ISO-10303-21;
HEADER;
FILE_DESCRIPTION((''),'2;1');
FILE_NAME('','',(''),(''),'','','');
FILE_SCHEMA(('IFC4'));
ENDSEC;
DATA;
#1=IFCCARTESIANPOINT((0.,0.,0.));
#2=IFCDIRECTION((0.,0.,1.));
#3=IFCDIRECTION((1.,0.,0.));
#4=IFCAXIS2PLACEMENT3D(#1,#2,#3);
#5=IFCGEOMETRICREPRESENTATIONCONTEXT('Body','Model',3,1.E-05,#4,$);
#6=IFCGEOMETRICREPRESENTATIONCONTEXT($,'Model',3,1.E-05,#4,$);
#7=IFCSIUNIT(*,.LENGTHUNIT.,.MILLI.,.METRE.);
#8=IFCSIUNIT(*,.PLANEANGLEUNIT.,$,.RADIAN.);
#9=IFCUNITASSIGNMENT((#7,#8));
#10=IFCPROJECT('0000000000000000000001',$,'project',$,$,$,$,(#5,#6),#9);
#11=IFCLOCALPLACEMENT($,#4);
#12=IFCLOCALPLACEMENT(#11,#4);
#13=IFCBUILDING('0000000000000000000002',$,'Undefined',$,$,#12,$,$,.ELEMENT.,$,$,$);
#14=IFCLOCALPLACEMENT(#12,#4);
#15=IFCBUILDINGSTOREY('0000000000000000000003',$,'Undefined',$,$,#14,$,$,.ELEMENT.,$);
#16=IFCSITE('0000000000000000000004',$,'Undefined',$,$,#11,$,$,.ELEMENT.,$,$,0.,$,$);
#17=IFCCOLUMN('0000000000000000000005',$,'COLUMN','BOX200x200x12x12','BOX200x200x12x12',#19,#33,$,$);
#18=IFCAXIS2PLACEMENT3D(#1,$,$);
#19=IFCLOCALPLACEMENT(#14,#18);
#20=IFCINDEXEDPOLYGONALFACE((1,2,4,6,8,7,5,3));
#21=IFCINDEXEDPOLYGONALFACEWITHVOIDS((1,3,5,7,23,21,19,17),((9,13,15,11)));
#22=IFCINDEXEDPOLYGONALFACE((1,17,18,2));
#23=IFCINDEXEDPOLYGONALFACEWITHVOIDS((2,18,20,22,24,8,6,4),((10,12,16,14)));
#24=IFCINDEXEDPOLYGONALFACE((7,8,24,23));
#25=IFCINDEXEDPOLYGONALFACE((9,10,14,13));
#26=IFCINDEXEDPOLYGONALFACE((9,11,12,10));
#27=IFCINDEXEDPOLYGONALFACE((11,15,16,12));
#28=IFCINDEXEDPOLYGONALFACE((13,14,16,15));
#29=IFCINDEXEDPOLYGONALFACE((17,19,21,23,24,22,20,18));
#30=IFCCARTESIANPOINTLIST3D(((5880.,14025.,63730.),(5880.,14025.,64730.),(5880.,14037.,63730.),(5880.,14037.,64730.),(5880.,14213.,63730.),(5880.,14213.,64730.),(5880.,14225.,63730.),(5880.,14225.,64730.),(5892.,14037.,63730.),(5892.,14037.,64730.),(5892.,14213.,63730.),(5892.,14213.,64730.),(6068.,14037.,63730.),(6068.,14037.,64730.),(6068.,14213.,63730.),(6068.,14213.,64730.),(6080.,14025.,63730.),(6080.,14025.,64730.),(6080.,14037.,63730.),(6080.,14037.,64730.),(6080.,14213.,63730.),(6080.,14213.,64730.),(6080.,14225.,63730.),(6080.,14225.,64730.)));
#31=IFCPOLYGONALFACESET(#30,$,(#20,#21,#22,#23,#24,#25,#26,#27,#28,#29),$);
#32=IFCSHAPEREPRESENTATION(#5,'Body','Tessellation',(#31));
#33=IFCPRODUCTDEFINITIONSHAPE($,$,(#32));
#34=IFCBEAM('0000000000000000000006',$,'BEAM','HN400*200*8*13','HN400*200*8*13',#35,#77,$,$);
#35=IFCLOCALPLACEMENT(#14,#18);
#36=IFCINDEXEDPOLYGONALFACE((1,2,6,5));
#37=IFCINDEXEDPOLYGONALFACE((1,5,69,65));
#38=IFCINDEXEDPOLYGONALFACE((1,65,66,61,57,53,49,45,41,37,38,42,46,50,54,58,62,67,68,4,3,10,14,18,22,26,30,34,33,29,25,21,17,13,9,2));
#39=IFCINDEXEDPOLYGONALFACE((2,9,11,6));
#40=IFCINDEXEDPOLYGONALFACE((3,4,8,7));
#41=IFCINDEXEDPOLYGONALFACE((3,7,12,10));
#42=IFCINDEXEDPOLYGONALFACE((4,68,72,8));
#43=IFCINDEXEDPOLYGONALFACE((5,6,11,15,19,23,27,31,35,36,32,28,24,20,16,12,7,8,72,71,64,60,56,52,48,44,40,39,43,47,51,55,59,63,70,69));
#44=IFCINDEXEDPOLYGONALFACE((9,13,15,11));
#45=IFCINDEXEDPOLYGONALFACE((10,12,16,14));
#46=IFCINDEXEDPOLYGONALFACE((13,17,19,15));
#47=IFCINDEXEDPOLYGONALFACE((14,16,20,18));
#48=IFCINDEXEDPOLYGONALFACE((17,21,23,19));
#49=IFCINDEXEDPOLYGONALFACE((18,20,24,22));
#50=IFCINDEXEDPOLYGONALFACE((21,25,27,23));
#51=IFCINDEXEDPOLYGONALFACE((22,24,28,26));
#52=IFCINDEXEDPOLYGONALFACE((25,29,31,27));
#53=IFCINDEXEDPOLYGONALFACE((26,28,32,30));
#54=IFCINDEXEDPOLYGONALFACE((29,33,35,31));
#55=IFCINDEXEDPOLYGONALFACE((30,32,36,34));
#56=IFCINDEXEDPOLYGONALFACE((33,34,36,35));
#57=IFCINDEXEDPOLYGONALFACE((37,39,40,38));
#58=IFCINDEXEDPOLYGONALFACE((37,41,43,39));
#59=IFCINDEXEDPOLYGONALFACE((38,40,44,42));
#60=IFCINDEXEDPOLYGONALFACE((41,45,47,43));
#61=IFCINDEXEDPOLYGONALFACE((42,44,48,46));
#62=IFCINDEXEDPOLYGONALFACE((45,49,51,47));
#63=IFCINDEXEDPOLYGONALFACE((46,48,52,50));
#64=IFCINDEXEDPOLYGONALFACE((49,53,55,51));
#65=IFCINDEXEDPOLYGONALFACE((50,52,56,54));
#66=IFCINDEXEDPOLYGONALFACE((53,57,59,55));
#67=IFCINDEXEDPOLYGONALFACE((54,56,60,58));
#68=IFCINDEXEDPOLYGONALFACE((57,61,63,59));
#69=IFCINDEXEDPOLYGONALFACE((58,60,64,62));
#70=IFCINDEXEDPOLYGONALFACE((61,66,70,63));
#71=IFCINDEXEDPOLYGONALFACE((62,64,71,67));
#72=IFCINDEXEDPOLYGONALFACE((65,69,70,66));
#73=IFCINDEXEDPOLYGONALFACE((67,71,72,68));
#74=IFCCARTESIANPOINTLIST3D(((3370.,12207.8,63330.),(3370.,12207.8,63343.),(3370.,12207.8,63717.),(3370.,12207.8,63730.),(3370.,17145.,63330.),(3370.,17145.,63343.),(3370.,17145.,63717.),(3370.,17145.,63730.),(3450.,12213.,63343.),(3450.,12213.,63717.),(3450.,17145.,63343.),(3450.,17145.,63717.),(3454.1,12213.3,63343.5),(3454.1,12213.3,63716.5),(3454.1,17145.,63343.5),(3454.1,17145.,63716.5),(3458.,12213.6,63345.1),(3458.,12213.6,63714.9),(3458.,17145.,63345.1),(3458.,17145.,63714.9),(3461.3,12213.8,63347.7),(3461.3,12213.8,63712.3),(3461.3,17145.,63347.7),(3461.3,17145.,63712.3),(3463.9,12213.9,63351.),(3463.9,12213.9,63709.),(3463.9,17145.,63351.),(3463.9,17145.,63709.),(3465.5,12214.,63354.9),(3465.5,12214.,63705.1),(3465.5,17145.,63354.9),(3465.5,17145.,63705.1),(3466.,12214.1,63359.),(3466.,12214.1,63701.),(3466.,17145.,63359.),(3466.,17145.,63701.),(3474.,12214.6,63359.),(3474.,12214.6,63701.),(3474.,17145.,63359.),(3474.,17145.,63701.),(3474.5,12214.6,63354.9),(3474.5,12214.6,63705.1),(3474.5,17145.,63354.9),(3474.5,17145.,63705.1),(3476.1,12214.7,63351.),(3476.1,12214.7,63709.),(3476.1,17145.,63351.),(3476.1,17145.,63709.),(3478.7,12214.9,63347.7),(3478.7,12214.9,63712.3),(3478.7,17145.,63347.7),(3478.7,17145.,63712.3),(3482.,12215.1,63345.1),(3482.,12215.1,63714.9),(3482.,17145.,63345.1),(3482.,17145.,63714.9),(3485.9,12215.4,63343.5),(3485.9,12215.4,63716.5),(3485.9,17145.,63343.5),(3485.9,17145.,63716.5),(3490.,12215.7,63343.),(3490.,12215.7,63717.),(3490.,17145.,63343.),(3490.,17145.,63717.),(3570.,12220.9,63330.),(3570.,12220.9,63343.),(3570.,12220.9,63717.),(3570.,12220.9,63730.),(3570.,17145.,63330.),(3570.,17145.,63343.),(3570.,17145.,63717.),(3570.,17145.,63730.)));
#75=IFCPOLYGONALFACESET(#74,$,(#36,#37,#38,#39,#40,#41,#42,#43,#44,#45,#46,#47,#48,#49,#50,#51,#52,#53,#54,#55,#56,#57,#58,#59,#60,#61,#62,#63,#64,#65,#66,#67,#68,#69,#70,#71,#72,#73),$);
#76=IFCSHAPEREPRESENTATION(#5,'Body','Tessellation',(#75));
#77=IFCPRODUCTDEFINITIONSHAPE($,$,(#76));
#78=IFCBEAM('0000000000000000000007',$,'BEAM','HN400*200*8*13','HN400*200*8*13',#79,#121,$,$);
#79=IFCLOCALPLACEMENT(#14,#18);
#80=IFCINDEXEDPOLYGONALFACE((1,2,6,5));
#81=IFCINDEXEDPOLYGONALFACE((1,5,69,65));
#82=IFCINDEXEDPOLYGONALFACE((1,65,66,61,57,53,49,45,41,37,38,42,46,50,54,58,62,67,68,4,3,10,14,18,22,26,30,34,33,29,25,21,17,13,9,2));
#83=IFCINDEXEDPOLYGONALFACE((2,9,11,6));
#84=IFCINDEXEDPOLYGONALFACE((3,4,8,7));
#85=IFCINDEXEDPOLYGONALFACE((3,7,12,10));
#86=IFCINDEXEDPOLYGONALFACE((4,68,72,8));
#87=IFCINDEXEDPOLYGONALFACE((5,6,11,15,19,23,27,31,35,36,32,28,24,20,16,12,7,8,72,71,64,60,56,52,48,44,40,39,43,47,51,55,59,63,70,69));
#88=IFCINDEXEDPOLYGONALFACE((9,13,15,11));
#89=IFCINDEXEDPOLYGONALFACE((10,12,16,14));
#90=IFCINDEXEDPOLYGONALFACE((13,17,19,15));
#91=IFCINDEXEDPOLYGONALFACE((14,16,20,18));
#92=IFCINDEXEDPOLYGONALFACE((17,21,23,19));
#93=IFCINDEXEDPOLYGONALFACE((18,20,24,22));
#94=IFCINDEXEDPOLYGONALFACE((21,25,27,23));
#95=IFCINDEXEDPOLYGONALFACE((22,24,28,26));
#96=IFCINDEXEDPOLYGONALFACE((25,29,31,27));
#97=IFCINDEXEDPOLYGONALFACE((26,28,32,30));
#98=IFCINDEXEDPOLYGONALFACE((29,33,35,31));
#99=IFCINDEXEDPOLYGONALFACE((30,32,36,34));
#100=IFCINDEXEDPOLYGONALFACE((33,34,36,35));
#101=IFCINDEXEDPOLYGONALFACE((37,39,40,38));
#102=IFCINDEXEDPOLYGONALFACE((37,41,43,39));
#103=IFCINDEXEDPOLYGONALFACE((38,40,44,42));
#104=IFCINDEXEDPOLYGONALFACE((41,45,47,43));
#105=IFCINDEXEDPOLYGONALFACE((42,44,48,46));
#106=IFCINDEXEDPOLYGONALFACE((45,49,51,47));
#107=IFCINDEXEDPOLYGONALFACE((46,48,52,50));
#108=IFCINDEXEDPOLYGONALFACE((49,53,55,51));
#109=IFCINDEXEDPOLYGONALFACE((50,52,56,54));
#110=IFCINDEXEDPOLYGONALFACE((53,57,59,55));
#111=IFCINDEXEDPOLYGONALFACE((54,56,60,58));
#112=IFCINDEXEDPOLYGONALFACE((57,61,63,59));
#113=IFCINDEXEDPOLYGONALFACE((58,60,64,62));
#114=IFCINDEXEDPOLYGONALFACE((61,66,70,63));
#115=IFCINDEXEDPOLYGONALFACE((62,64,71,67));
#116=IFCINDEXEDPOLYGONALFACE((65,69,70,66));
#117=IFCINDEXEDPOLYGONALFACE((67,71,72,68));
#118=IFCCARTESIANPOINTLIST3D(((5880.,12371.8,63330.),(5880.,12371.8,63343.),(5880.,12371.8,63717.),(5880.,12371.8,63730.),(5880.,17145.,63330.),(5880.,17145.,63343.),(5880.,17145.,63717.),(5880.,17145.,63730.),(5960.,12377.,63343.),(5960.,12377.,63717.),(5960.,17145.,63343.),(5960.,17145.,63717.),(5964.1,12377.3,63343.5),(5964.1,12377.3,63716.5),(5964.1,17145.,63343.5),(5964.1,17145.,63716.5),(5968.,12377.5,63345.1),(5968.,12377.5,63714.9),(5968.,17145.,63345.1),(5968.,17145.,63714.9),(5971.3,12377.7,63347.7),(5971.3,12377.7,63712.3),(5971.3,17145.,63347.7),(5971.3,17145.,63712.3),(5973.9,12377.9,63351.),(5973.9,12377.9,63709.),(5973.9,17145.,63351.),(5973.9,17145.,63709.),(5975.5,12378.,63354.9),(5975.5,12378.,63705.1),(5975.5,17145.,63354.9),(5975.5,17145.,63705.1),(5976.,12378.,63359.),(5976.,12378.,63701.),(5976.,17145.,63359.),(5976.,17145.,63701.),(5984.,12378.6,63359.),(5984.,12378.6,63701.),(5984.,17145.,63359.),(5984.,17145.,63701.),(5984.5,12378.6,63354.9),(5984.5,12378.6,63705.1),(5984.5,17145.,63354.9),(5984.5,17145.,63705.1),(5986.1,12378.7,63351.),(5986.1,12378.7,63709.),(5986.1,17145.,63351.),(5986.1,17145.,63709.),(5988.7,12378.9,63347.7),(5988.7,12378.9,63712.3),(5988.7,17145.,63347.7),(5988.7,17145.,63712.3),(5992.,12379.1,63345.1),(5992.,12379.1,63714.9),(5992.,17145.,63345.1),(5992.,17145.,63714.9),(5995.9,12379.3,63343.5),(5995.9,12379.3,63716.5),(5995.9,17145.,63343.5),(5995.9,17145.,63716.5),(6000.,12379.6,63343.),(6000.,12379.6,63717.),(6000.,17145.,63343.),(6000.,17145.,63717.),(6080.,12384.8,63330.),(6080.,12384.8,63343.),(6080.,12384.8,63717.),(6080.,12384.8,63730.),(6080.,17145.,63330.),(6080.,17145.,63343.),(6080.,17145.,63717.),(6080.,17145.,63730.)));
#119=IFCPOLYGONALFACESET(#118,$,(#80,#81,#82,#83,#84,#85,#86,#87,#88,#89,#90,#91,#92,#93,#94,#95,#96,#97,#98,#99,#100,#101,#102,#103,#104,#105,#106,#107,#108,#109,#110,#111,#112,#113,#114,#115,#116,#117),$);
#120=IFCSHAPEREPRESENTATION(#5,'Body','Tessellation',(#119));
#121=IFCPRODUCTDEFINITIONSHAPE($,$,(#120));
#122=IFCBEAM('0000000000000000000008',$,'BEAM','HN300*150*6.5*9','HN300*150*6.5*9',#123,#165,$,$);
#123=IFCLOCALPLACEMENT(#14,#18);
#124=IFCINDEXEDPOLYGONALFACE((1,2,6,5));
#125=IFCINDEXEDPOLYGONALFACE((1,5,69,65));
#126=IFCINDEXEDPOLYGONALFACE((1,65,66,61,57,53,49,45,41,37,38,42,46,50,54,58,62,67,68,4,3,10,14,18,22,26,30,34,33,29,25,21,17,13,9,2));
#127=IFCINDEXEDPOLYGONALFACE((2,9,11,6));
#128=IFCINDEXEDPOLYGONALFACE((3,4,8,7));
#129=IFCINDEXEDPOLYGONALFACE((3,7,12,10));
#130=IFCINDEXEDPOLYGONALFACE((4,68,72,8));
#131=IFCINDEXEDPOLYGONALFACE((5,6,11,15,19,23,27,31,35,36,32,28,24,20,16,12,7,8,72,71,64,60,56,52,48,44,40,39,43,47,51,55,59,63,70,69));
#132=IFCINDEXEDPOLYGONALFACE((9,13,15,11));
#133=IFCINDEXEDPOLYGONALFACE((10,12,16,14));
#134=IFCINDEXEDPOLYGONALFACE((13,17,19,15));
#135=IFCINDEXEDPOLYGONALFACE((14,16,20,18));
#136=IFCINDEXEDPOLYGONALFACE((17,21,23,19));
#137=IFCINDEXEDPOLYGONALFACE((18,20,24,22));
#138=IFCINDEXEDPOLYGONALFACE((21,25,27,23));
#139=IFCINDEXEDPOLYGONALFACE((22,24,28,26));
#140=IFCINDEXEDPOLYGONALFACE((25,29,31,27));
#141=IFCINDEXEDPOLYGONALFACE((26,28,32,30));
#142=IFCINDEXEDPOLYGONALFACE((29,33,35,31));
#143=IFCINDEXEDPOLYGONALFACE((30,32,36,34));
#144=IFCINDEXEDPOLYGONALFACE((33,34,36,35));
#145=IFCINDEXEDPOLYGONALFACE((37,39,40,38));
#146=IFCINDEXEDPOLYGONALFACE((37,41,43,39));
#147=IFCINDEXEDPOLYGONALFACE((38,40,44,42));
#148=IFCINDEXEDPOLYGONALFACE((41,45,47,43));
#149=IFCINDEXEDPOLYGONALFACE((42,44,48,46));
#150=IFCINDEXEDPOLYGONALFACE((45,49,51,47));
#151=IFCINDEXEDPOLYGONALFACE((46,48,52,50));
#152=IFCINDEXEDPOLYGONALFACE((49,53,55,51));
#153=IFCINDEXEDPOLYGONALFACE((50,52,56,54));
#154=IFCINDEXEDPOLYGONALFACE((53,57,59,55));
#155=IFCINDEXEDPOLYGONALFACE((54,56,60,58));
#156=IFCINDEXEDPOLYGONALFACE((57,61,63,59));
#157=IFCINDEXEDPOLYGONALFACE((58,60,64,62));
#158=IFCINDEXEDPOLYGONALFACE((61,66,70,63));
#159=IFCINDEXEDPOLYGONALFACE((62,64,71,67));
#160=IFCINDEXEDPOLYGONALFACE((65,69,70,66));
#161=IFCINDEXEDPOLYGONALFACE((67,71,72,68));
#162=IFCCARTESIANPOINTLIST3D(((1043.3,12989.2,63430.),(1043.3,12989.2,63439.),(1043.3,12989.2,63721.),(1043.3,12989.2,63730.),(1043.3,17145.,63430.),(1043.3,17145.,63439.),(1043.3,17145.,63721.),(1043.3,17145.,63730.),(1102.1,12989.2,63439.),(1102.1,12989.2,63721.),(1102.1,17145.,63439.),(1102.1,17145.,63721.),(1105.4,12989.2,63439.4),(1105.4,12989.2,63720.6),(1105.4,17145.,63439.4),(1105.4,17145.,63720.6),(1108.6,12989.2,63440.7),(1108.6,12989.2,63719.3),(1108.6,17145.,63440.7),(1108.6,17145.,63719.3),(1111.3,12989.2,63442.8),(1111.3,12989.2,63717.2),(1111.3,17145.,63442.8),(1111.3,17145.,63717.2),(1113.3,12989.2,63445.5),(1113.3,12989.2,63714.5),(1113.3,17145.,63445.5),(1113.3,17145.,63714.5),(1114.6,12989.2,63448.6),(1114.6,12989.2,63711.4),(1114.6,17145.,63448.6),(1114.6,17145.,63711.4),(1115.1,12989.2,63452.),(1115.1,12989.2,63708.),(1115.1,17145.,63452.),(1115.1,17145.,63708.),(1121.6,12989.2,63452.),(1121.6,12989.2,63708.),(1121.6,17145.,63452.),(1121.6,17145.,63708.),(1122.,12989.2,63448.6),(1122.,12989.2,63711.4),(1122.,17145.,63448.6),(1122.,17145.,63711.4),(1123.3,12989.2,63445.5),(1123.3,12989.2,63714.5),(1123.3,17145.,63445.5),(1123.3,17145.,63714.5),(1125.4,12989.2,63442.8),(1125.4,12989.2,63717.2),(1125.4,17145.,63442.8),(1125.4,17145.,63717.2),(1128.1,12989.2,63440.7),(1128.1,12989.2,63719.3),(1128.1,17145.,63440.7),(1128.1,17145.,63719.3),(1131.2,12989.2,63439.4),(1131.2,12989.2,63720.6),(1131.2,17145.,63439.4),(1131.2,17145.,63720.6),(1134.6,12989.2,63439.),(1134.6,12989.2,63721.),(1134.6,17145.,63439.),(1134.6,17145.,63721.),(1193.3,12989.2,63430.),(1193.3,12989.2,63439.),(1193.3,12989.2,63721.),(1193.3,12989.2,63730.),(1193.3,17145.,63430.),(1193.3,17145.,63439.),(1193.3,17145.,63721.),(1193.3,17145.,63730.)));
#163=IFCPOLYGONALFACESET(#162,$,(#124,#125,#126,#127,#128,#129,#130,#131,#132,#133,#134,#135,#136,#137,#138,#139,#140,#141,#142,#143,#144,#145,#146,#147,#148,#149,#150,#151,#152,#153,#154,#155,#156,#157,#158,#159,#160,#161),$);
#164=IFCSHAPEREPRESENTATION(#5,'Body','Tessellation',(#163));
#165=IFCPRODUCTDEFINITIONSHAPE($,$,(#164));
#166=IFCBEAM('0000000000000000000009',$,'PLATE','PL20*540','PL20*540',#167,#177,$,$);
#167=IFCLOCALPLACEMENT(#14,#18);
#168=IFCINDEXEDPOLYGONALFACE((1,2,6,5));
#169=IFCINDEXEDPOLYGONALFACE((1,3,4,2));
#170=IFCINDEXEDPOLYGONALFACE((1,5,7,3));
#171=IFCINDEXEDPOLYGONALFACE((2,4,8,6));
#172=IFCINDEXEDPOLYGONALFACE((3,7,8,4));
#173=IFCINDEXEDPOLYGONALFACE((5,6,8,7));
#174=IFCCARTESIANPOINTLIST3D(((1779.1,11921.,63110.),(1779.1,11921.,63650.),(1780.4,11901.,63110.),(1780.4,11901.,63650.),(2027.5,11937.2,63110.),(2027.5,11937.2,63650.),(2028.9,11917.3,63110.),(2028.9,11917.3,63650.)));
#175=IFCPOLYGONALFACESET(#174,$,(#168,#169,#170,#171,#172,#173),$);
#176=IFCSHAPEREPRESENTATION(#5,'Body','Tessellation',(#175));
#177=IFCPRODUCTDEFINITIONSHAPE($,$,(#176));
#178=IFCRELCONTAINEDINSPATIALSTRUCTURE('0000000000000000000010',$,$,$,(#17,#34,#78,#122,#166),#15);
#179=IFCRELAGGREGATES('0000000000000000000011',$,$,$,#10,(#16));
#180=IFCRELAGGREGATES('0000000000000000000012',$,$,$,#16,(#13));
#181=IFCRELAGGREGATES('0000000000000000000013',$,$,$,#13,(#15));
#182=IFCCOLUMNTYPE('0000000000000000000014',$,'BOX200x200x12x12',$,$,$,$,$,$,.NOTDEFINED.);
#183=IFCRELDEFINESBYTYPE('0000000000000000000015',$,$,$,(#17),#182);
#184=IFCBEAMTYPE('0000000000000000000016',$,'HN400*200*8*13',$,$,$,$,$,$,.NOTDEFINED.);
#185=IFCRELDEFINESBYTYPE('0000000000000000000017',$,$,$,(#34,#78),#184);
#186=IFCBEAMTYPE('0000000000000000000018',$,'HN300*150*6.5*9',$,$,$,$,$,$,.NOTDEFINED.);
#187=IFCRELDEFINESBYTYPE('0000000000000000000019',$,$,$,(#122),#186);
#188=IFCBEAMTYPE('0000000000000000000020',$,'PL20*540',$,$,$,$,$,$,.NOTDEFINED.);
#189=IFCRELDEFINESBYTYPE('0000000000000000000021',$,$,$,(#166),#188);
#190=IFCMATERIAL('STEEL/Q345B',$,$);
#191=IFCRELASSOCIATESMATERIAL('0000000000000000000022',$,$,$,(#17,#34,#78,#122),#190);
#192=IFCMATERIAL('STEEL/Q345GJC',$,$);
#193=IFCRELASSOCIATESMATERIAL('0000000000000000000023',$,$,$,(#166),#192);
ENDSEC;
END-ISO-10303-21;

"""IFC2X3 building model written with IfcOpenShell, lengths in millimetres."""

from ifc_helpers import new_model, si_unit, frame, origin_with_axes, origin_2d_with_axis, place, context, project, spatial, polyline, rectangle, i_section, outline, extrude, clip, halfspace, material, type_object, element, save


model = new_model("IFC2X3")

# Units and contexts
model_context_1 = context("Model", 3, precision=1e-05, world=origin_with_axes(), identifier="Body")
model_context_2 = context("Model", 3, precision=1e-05, world=origin_with_axes())
ifc_project = project(units=[si_unit("LENGTHUNIT", "METRE", prefix="MILLI"), si_unit("PLANEANGLEUNIT", "RADIAN")], contexts=[model_context_1, model_context_2])

# Site, building, storey
site_placement = place(None, origin_with_axes())
site = spatial("IfcSite", under=ifc_project, at=site_placement, Name="Undefined", CompositionType="ELEMENT", RefElevation=0.0)
building_placement = place(site_placement, origin_with_axes())
building = spatial("IfcBuilding", under=site, at=building_placement, Name="Undefined", CompositionType="ELEMENT")
storey_placement = place(building_placement, origin_with_axes())
storey = spatial("IfcBuildingStorey", under=building, at=storey_placement, Name="Undefined", CompositionType="ELEMENT")

# Column
ifc_material_1 = material(Name="STEEL/Q345B")
column_type = type_object("IfcColumnType", Name="BOX200x200x12x12", PredefinedType="NOTDEFINED")
column_placement = place(storey_placement, frame((5980.0, 14125.0, 63730.0), z_axis=(0.0, 0.0, 1.0), x_axis=(1.0, 0.0, 0.0)))
element("IfcColumn", 1, at=column_placement, inside=storey, type_object=column_type, material=ifc_material_1, Name="COLUMN", Description="BOX200x200x12x12", ObjectType="BOX200x200x12x12", context=model_context_1, shape_type="SweptSolid", body=[
    extrude(outline(polyline([(-100.0, -100.0), (100.0, -100.0), (100.0, -88.0), (100.0, 88.0), (100.0, 100.0), (-100.0, 100.0), (-100.0, 88.0), (-100.0, -88.0), (-100.0, -100.0)]), holes=[polyline([(-88.0, -88.0), (-88.0, 88.0), (88.0, 88.0), (88.0, -88.0), (-88.0, -88.0)])]), frame((0.0, 0.0, 1000.0), z_axis=(0.0, 0.0, -1.0), x_axis=(-1.0, 0.0, 0.0)), (0.0, 0.0, 1.0), 1000.0),
])

# Beams
beam_type_1 = type_object("IfcBeamType", Name="HN400*200*8*13", PredefinedType="NOTDEFINED")
beam_1_placement = place(storey_placement, frame((3470.0, 12221.0, 63530.0), z_axis=(0.0, 0.0, 1.0), x_axis=(0.0, 1.0, 0.0)))
element("IfcBeam", 2, at=beam_1_placement, inside=storey, type_object=beam_type_1, material=ifc_material_1, Name="BEAM", Description="HN400*200*8*13", ObjectType="HN400*200*8*13", context=model_context_1, shape_type="Clipping", body=[
    clip(clip(extrude(i_section(OverallWidth=200.0, OverallDepth=400.0, WebThickness=8.0, FlangeThickness=13.0, FilletRadius=16.0, at=origin_2d_with_axis()), frame((4924.0, 0.0, 0.0), z_axis=(-1.0, 0.0, 0.0), x_axis=(0.0, -1.0, 0.0)), (0.0, 0.0, 1.0), 4937.3), halfspace(frame((-7.5, 13.2, 300.0), z_axis=(-0.997873, -0.065183, 0.0), x_axis=(0.0, 0.0, -1.0)), False)), halfspace(frame((4924.0, 0.0, 300.0), z_axis=(1.0, 0.0, 0.0), x_axis=(0.0, 0.0, -1.0)), False)),
])
beam_2_placement = place(storey_placement, frame((5980.0, 12384.9, 63530.0), z_axis=(0.0, 0.0, 1.0), x_axis=(0.0, 1.0, 0.0)))
element("IfcBeam", 3, at=beam_2_placement, inside=storey, type_object=beam_type_1, material=ifc_material_1, Name="BEAM", Description="HN400*200*8*13", ObjectType="HN400*200*8*13", context=model_context_1, shape_type="Clipping", body=[
    clip(clip(extrude(i_section(OverallWidth=200.0, OverallDepth=400.0, WebThickness=8.0, FlangeThickness=13.0, FilletRadius=16.0, at=origin_2d_with_axis()), frame((4760.1, 0.0, 0.0), z_axis=(-1.0, 0.0, 0.0), x_axis=(0.0, -1.0, 0.0)), (0.0, 0.0, 1.0), 4773.3), halfspace(frame((-7.5, 13.2, 300.0), z_axis=(-0.997873, -0.065183, 0.0), x_axis=(0.0, 0.0, -1.0)), False)), halfspace(frame((4760.1, 0.0, 300.0), z_axis=(1.0, 0.0, 0.0), x_axis=(0.0, 0.0, -1.0)), False)),
])
beam_type_2 = type_object("IfcBeamType", Name="HN300*150*6.5*9", PredefinedType="NOTDEFINED")
beam_3_placement = place(storey_placement, frame((1118.3, 12489.8, 63580.0), z_axis=(0.0, 0.0, 1.0), x_axis=(0.0, 1.0, 0.0)))
element("IfcBeam", 4, at=beam_3_placement, inside=storey, type_object=beam_type_2, material=ifc_material_1, Name="BEAM", Description="HN300*150*6.5*9", ObjectType="HN300*150*6.5*9", context=model_context_1, shape_type="SweptSolid", body=[
    extrude(i_section(OverallWidth=150.0, OverallDepth=300.0, WebThickness=6.5, FlangeThickness=9.0, FilletRadius=13.0, at=origin_2d_with_axis()), frame((4655.2, 0.0, 0.0), z_axis=(-1.0, 0.0, 0.0), x_axis=(0.0, -1.0, 0.0)), (0.0, 0.0, 1.0), 4155.8),
])
ifc_material_2 = material(Name="STEEL/Q345GJC")
beam_type_3 = type_object("IfcBeamType", Name="PL20*540", PredefinedType="NOTDEFINED")
beam_4_placement = place(storey_placement, frame((1779.7, 11911.0, 63380.0), z_axis=(0.0, 0.0, 1.0), x_axis=(0.997873, 0.065184, 0.0)))
element("IfcBeam", 5, at=beam_4_placement, inside=storey, type_object=beam_type_3, material=ifc_material_2, Name="PLATE", Description="PL20*540", ObjectType="PL20*540", context=model_context_1, shape_type="SweptSolid", body=[
    extrude(rectangle(XDim=20.0, YDim=540.0, at=origin_2d_with_axis()), frame((249.0, 0.0, 0.0), z_axis=(-1.0, 0.0, 0.0), x_axis=(0.0, -1.0, 0.0)), (0.0, 0.0, 1.0), 249.0),
])

save(model, "model.ifc")
